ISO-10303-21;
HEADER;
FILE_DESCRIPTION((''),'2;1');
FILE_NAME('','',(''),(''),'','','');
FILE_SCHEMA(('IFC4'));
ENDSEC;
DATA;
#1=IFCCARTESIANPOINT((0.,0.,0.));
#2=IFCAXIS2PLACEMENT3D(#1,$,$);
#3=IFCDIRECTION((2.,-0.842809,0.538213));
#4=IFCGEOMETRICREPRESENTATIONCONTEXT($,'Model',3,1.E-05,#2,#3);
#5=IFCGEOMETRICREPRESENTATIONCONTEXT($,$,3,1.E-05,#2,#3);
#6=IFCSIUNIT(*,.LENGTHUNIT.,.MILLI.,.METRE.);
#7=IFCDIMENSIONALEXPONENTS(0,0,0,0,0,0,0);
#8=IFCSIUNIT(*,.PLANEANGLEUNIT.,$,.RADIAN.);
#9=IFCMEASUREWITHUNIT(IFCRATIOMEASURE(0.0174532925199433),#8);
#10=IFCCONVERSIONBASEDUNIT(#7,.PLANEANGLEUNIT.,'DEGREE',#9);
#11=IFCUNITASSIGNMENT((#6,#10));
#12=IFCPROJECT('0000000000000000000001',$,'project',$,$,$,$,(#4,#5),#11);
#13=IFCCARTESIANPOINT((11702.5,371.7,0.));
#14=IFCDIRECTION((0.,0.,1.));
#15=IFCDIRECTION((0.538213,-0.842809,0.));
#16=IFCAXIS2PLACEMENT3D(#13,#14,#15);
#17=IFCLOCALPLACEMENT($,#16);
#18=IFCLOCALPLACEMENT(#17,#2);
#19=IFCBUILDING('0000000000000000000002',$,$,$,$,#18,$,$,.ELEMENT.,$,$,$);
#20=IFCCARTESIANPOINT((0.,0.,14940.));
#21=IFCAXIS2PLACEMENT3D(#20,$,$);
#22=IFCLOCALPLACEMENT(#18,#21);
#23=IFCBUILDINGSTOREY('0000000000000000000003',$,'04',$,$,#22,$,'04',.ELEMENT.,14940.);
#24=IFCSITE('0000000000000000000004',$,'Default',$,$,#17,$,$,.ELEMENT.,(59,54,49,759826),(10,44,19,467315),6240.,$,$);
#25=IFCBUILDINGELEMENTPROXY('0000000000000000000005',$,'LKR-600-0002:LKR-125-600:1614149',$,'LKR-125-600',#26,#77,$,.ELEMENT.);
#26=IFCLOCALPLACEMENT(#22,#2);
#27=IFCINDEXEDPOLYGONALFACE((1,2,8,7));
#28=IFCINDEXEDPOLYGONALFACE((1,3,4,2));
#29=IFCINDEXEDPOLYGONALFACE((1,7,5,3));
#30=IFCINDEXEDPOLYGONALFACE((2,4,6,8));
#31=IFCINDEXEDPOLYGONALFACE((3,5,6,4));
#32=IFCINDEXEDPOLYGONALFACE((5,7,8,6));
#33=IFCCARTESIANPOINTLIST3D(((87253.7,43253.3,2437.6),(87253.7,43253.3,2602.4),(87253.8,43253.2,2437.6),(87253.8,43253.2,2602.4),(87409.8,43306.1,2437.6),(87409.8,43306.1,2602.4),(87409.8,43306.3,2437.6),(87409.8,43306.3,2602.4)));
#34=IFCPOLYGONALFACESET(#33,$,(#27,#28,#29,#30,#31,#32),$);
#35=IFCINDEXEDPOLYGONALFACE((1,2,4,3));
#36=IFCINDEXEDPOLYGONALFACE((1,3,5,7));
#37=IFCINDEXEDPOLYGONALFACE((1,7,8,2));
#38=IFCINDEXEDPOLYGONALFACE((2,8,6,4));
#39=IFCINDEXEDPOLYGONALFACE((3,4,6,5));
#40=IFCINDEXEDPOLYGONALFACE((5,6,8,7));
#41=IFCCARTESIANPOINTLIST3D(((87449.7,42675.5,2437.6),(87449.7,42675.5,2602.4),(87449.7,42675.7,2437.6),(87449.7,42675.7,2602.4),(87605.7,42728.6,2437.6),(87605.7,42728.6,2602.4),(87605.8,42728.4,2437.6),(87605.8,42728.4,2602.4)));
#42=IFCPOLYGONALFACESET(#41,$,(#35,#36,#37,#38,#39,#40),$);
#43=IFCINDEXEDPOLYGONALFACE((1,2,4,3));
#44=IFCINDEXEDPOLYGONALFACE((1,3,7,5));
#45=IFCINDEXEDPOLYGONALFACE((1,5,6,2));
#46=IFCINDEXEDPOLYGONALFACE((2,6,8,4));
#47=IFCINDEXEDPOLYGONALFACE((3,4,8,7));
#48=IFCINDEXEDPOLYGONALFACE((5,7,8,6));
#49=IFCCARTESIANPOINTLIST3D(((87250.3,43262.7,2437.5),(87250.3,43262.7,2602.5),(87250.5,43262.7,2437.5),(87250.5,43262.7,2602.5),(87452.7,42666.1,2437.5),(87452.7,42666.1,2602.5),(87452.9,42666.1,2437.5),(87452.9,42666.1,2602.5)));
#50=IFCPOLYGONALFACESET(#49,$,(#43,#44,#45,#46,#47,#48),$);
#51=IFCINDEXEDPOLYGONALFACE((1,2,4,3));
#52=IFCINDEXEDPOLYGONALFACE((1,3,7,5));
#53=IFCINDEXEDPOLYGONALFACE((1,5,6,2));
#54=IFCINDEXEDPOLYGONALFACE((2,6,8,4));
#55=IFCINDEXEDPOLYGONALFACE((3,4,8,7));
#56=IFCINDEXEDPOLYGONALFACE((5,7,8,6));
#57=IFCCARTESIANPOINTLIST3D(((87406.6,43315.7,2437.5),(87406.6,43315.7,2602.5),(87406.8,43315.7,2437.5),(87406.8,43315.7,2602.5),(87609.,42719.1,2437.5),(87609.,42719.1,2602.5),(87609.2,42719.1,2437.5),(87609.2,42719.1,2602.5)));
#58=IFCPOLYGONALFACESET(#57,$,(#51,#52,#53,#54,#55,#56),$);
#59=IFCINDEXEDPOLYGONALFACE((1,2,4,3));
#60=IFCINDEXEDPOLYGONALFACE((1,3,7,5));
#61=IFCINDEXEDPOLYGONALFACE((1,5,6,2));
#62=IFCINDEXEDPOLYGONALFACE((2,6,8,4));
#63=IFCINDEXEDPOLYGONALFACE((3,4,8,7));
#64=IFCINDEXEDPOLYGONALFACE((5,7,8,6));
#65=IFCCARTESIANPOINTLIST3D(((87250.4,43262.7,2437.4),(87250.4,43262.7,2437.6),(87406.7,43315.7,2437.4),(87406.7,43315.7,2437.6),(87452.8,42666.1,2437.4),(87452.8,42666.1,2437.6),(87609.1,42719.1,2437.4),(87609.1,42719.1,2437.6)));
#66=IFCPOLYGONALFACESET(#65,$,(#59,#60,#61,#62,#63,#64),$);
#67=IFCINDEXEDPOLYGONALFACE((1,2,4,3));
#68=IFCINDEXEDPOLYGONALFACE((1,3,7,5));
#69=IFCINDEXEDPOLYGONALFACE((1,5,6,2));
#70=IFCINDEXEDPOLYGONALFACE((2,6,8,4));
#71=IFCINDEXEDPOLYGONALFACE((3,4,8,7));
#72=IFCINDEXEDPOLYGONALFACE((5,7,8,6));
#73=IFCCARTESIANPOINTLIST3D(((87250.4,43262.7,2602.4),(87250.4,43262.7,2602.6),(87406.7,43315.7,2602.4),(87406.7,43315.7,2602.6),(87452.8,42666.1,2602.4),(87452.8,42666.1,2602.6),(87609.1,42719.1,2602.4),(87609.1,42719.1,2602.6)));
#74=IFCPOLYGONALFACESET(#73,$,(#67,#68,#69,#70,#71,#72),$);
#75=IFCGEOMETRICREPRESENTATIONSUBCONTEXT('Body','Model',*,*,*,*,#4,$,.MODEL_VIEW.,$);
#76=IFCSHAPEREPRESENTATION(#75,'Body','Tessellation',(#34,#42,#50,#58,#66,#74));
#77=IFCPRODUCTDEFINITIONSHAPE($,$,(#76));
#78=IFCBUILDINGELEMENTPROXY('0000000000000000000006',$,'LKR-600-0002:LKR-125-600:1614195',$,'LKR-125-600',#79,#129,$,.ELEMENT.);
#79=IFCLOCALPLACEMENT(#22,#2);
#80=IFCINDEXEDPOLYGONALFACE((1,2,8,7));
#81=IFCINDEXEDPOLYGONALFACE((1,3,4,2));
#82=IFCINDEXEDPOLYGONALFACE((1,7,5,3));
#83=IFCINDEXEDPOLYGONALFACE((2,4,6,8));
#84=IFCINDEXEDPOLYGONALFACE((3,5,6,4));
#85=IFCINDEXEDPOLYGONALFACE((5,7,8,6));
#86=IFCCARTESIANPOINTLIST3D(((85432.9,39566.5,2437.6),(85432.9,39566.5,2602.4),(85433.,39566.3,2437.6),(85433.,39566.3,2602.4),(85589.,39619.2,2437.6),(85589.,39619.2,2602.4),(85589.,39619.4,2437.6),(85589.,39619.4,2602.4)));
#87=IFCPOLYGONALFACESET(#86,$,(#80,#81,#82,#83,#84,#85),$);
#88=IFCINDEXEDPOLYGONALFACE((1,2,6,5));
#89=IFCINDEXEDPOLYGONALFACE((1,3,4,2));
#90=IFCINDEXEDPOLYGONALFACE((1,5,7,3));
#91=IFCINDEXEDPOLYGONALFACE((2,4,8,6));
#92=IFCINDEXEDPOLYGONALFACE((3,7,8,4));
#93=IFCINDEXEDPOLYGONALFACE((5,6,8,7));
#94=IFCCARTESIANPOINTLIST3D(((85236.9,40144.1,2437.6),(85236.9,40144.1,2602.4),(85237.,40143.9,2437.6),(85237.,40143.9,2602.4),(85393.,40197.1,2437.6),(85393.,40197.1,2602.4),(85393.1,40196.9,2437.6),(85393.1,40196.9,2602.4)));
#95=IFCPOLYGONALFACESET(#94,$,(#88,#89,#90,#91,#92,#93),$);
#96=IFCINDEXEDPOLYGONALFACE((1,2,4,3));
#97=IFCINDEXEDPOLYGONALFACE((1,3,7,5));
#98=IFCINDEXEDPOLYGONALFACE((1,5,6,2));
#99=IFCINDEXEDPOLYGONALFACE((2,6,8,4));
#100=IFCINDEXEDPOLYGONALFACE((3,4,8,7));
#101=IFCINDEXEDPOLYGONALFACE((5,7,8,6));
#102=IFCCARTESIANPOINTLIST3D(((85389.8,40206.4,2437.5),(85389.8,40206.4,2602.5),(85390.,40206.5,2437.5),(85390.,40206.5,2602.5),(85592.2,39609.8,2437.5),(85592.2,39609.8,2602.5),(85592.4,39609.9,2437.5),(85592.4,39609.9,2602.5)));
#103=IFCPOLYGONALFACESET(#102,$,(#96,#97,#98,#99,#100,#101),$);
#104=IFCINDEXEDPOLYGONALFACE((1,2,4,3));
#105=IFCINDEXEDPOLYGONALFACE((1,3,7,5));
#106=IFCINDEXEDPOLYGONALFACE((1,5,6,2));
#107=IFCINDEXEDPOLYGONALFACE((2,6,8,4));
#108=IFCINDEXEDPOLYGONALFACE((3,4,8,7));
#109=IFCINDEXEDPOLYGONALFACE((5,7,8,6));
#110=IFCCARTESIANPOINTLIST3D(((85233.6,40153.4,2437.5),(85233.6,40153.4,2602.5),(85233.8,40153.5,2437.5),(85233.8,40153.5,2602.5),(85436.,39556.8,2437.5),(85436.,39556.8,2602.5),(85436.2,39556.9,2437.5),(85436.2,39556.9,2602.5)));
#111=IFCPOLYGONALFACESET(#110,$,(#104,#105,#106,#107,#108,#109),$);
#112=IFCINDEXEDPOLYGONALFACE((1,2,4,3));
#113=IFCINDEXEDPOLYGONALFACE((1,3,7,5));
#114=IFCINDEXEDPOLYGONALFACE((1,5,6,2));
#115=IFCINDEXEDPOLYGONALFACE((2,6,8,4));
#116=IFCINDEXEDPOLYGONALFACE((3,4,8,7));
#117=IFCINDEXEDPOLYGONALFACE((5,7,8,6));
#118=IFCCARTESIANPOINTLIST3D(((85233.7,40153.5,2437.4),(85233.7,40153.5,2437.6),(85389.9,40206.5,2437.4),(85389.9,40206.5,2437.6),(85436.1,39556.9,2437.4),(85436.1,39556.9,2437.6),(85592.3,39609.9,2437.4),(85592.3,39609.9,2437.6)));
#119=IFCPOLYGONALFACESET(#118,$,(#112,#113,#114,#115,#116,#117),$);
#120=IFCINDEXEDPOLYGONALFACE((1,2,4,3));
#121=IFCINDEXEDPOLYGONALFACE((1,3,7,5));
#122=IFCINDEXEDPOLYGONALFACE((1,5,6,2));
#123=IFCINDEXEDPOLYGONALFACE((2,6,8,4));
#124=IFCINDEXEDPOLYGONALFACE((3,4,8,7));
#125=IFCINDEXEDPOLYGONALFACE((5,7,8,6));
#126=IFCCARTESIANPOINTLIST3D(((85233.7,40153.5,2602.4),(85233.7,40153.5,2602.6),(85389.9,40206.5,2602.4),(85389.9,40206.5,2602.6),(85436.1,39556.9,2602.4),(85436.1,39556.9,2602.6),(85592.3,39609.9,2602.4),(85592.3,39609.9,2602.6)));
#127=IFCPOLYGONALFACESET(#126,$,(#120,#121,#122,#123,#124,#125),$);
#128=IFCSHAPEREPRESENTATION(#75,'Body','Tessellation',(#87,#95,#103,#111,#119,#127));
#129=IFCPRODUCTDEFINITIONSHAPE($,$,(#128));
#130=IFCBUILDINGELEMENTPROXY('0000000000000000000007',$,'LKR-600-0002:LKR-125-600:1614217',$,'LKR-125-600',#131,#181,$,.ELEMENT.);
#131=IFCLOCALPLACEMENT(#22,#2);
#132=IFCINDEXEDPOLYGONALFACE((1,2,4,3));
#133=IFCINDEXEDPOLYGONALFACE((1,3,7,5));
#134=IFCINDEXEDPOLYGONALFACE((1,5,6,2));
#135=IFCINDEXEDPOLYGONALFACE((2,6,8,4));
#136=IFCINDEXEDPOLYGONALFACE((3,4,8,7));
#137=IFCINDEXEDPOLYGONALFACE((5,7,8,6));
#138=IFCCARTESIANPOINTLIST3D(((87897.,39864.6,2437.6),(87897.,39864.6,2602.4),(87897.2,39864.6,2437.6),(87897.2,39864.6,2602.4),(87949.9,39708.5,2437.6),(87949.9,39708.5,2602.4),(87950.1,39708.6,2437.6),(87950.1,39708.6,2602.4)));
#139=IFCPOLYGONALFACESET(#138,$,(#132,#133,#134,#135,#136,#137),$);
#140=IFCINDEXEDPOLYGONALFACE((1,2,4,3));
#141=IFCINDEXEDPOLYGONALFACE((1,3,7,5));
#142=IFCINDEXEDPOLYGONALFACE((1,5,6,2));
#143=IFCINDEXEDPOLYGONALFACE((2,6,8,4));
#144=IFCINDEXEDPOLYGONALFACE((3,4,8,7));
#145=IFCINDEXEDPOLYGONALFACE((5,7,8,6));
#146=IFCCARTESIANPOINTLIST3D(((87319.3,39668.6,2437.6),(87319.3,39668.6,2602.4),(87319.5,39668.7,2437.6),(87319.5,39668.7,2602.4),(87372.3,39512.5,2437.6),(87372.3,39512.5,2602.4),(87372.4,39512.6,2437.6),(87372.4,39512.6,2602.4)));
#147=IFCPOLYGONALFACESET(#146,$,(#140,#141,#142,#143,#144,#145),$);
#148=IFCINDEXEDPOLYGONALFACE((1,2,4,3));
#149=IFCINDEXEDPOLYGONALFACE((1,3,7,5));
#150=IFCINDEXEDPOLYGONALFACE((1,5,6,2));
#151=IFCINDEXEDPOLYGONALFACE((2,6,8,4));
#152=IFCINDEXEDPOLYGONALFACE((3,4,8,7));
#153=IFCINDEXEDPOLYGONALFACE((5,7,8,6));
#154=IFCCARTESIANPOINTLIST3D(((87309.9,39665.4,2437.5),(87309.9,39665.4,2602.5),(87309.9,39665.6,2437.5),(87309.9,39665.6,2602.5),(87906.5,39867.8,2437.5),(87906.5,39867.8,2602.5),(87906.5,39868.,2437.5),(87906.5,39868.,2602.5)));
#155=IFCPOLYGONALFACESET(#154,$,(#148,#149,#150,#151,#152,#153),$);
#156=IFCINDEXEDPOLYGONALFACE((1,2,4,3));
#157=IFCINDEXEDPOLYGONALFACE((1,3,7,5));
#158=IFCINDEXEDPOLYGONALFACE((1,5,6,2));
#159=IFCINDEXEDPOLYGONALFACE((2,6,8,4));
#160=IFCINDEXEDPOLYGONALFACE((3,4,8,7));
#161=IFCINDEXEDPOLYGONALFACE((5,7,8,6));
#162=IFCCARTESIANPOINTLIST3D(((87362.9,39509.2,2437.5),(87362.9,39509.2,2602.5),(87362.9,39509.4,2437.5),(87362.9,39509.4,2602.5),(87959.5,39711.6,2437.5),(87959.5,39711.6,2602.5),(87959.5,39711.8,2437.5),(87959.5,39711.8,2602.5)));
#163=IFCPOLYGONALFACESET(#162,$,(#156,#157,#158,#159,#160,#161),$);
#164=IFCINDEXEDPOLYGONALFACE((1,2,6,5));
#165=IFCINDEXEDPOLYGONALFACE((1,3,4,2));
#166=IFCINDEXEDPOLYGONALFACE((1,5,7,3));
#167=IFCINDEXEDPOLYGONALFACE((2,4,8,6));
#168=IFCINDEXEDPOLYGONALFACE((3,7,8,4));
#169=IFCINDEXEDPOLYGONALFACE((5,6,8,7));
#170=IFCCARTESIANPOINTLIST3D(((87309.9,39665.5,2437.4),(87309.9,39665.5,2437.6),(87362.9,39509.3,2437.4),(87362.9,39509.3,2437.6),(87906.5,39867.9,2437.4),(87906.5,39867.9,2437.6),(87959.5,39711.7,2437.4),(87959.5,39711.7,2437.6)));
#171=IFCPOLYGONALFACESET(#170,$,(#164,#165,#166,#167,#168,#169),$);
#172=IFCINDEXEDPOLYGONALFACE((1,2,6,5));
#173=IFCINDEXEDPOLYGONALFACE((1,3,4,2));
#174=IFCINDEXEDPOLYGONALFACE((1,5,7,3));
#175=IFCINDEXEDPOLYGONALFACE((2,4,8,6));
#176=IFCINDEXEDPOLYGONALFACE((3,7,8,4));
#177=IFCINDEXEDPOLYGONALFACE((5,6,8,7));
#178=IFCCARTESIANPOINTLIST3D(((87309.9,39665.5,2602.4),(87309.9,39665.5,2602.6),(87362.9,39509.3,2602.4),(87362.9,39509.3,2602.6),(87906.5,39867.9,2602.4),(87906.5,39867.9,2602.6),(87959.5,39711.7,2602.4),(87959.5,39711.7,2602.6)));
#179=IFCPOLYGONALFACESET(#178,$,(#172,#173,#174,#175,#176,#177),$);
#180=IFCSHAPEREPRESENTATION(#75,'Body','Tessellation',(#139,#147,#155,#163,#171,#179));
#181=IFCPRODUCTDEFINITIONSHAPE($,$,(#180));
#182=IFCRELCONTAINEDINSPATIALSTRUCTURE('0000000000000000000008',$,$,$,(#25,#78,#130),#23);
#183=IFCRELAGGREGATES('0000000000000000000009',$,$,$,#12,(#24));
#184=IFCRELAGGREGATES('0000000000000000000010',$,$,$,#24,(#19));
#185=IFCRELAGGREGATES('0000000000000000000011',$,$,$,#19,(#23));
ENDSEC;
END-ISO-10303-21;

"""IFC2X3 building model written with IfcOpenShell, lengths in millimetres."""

from ifc_helpers import new_model, entity, si_unit, converted_unit, direction, frame, frame_2d, origin, place, context, subcontext, project, spatial, rectangle, extrude, source, transform, mapped, element, save


model = new_model("IFC2X3")

# Units and contexts
model_context = context("Model", 3, precision=1e-05, world=origin(), true_north=direction((2.0, -0.842809, 0.538213)))
context_of_model = context(None, 3, precision=1e-05, world=origin(), true_north=direction((2.0, -0.842809, 0.538213)))
body_context = subcontext(model_context, "Body", "Model", "MODEL_VIEW")
ifc_project = project(units=[si_unit("LENGTHUNIT", "METRE", prefix="MILLI"), converted_unit("PLANEANGLEUNIT", "DEGREE", entity("IfcRatioMeasure", 0.0174532925199433), si_unit("PLANEANGLEUNIT", "RADIAN"), dimensions=[0, 0, 0, 0, 0, 0, 0])], contexts=[model_context, context_of_model])

# Site, building, storey
site_placement = place(None, frame((11702.5, 371.7, 0.0), z_axis=(0.0, 0.0, 1.0), x_axis=(0.538213, -0.842809, 0.0)))
site = spatial("IfcSite", under=ifc_project, at=site_placement, Name="Default", CompositionType="ELEMENT", RefLatitude=(59, 54, 49, 759826), RefLongitude=(10, 44, 19, 467315), RefElevation=6240.0)
building_placement = place(site_placement, origin())
building = spatial("IfcBuilding", under=site, at=building_placement, CompositionType="ELEMENT")
storey_placement = place(building_placement, frame((0.0, 0.0, 14940.0)))
storey = spatial("IfcBuildingStorey", under=building, at=storey_placement, Name="04", LongName="04", CompositionType="ELEMENT", Elevation=14940.0)

# Building element proxies
shared_shape_1 = source(origin(), body_context, "Body", "SweptSolid", [
    extrude(rectangle(XDim=0.2, YDim=164.8, at=frame_2d((0.0, 0.0), x_axis=(1.0, 0.0))), frame((305.0, 0.0, -82.4)), (0.0, 0.0, 1.0), 164.8),
    extrude(rectangle(XDim=0.2, YDim=164.8, at=frame_2d((0.0, 0.0), x_axis=(1.0, 0.0))), frame((-305.0, 0.0, -82.4)), (0.0, 0.0, 1.0), 164.8),
    extrude(rectangle(XDim=0.2, YDim=630.0, at=frame_2d((0.0, 0.0), x_axis=(1.0, 0.0))), frame((0.0, 82.5, -82.5), z_axis=(0.0, 0.0, 1.0), x_axis=(0.0, 1.0, 0.0)), (0.0, 0.0, 1.0), 165.0),
    extrude(rectangle(XDim=0.2, YDim=630.0, at=frame_2d((0.0, 0.0), x_axis=(1.0, 0.0))), frame((0.0, -82.5, -82.5), z_axis=(0.0, 0.0, 1.0), x_axis=(0.0, 1.0, 0.0)), (0.0, 0.0, 1.0), 165.0),
    extrude(rectangle(XDim=165.0, YDim=630.0, at=frame_2d((0.0, 0.0), x_axis=(1.0, 0.0))), frame((0.0, 0.0, -82.6), z_axis=(0.0, 0.0, 1.0), x_axis=(0.0, -1.0, 0.0)), (0.0, 0.0, 1.0), 0.2),
    extrude(rectangle(XDim=165.0, YDim=630.0, at=frame_2d((0.0, 0.0), x_axis=(1.0, 0.0))), frame((0.0, 0.0, 82.4), z_axis=(0.0, 0.0, 1.0), x_axis=(0.0, -1.0, 0.0)), (0.0, 0.0, 1.0), 0.2),
])
for number, where, z_axis, x_axis, name in (
    (1, (87429.8, 42990.9, 2520.0), (0.0, 0.0, 1.0), (-0.321274, 0.946986, 0.0), "LKR-600-0002:LKR-125-600:1614149"),
    (2, (85413.0, 39881.7, 2520.0), (0.0, 0.0, 1.0), (0.321274, -0.946986, 0.0), "LKR-600-0002:LKR-125-600:1614195"),
    (3, (87634.7, 39688.6, 2520.0), (0.0, 0.0, 1.0), (0.946986, 0.321274, 0.0), "LKR-600-0002:LKR-125-600:1614217"),
):
    element("IfcBuildingElementProxy", number, at=place(storey_placement, frame(where, z_axis=z_axis, x_axis=x_axis)), inside=storey, Name=name, ObjectType="LKR-125-600", CompositionType="ELEMENT", context=body_context, shape_type="MappedRepresentation", body=[
        mapped(shared_shape_1, transform((0.0, 0.0, 0.0), scale=1.0)),
    ])

save(model, "model.ifc")
